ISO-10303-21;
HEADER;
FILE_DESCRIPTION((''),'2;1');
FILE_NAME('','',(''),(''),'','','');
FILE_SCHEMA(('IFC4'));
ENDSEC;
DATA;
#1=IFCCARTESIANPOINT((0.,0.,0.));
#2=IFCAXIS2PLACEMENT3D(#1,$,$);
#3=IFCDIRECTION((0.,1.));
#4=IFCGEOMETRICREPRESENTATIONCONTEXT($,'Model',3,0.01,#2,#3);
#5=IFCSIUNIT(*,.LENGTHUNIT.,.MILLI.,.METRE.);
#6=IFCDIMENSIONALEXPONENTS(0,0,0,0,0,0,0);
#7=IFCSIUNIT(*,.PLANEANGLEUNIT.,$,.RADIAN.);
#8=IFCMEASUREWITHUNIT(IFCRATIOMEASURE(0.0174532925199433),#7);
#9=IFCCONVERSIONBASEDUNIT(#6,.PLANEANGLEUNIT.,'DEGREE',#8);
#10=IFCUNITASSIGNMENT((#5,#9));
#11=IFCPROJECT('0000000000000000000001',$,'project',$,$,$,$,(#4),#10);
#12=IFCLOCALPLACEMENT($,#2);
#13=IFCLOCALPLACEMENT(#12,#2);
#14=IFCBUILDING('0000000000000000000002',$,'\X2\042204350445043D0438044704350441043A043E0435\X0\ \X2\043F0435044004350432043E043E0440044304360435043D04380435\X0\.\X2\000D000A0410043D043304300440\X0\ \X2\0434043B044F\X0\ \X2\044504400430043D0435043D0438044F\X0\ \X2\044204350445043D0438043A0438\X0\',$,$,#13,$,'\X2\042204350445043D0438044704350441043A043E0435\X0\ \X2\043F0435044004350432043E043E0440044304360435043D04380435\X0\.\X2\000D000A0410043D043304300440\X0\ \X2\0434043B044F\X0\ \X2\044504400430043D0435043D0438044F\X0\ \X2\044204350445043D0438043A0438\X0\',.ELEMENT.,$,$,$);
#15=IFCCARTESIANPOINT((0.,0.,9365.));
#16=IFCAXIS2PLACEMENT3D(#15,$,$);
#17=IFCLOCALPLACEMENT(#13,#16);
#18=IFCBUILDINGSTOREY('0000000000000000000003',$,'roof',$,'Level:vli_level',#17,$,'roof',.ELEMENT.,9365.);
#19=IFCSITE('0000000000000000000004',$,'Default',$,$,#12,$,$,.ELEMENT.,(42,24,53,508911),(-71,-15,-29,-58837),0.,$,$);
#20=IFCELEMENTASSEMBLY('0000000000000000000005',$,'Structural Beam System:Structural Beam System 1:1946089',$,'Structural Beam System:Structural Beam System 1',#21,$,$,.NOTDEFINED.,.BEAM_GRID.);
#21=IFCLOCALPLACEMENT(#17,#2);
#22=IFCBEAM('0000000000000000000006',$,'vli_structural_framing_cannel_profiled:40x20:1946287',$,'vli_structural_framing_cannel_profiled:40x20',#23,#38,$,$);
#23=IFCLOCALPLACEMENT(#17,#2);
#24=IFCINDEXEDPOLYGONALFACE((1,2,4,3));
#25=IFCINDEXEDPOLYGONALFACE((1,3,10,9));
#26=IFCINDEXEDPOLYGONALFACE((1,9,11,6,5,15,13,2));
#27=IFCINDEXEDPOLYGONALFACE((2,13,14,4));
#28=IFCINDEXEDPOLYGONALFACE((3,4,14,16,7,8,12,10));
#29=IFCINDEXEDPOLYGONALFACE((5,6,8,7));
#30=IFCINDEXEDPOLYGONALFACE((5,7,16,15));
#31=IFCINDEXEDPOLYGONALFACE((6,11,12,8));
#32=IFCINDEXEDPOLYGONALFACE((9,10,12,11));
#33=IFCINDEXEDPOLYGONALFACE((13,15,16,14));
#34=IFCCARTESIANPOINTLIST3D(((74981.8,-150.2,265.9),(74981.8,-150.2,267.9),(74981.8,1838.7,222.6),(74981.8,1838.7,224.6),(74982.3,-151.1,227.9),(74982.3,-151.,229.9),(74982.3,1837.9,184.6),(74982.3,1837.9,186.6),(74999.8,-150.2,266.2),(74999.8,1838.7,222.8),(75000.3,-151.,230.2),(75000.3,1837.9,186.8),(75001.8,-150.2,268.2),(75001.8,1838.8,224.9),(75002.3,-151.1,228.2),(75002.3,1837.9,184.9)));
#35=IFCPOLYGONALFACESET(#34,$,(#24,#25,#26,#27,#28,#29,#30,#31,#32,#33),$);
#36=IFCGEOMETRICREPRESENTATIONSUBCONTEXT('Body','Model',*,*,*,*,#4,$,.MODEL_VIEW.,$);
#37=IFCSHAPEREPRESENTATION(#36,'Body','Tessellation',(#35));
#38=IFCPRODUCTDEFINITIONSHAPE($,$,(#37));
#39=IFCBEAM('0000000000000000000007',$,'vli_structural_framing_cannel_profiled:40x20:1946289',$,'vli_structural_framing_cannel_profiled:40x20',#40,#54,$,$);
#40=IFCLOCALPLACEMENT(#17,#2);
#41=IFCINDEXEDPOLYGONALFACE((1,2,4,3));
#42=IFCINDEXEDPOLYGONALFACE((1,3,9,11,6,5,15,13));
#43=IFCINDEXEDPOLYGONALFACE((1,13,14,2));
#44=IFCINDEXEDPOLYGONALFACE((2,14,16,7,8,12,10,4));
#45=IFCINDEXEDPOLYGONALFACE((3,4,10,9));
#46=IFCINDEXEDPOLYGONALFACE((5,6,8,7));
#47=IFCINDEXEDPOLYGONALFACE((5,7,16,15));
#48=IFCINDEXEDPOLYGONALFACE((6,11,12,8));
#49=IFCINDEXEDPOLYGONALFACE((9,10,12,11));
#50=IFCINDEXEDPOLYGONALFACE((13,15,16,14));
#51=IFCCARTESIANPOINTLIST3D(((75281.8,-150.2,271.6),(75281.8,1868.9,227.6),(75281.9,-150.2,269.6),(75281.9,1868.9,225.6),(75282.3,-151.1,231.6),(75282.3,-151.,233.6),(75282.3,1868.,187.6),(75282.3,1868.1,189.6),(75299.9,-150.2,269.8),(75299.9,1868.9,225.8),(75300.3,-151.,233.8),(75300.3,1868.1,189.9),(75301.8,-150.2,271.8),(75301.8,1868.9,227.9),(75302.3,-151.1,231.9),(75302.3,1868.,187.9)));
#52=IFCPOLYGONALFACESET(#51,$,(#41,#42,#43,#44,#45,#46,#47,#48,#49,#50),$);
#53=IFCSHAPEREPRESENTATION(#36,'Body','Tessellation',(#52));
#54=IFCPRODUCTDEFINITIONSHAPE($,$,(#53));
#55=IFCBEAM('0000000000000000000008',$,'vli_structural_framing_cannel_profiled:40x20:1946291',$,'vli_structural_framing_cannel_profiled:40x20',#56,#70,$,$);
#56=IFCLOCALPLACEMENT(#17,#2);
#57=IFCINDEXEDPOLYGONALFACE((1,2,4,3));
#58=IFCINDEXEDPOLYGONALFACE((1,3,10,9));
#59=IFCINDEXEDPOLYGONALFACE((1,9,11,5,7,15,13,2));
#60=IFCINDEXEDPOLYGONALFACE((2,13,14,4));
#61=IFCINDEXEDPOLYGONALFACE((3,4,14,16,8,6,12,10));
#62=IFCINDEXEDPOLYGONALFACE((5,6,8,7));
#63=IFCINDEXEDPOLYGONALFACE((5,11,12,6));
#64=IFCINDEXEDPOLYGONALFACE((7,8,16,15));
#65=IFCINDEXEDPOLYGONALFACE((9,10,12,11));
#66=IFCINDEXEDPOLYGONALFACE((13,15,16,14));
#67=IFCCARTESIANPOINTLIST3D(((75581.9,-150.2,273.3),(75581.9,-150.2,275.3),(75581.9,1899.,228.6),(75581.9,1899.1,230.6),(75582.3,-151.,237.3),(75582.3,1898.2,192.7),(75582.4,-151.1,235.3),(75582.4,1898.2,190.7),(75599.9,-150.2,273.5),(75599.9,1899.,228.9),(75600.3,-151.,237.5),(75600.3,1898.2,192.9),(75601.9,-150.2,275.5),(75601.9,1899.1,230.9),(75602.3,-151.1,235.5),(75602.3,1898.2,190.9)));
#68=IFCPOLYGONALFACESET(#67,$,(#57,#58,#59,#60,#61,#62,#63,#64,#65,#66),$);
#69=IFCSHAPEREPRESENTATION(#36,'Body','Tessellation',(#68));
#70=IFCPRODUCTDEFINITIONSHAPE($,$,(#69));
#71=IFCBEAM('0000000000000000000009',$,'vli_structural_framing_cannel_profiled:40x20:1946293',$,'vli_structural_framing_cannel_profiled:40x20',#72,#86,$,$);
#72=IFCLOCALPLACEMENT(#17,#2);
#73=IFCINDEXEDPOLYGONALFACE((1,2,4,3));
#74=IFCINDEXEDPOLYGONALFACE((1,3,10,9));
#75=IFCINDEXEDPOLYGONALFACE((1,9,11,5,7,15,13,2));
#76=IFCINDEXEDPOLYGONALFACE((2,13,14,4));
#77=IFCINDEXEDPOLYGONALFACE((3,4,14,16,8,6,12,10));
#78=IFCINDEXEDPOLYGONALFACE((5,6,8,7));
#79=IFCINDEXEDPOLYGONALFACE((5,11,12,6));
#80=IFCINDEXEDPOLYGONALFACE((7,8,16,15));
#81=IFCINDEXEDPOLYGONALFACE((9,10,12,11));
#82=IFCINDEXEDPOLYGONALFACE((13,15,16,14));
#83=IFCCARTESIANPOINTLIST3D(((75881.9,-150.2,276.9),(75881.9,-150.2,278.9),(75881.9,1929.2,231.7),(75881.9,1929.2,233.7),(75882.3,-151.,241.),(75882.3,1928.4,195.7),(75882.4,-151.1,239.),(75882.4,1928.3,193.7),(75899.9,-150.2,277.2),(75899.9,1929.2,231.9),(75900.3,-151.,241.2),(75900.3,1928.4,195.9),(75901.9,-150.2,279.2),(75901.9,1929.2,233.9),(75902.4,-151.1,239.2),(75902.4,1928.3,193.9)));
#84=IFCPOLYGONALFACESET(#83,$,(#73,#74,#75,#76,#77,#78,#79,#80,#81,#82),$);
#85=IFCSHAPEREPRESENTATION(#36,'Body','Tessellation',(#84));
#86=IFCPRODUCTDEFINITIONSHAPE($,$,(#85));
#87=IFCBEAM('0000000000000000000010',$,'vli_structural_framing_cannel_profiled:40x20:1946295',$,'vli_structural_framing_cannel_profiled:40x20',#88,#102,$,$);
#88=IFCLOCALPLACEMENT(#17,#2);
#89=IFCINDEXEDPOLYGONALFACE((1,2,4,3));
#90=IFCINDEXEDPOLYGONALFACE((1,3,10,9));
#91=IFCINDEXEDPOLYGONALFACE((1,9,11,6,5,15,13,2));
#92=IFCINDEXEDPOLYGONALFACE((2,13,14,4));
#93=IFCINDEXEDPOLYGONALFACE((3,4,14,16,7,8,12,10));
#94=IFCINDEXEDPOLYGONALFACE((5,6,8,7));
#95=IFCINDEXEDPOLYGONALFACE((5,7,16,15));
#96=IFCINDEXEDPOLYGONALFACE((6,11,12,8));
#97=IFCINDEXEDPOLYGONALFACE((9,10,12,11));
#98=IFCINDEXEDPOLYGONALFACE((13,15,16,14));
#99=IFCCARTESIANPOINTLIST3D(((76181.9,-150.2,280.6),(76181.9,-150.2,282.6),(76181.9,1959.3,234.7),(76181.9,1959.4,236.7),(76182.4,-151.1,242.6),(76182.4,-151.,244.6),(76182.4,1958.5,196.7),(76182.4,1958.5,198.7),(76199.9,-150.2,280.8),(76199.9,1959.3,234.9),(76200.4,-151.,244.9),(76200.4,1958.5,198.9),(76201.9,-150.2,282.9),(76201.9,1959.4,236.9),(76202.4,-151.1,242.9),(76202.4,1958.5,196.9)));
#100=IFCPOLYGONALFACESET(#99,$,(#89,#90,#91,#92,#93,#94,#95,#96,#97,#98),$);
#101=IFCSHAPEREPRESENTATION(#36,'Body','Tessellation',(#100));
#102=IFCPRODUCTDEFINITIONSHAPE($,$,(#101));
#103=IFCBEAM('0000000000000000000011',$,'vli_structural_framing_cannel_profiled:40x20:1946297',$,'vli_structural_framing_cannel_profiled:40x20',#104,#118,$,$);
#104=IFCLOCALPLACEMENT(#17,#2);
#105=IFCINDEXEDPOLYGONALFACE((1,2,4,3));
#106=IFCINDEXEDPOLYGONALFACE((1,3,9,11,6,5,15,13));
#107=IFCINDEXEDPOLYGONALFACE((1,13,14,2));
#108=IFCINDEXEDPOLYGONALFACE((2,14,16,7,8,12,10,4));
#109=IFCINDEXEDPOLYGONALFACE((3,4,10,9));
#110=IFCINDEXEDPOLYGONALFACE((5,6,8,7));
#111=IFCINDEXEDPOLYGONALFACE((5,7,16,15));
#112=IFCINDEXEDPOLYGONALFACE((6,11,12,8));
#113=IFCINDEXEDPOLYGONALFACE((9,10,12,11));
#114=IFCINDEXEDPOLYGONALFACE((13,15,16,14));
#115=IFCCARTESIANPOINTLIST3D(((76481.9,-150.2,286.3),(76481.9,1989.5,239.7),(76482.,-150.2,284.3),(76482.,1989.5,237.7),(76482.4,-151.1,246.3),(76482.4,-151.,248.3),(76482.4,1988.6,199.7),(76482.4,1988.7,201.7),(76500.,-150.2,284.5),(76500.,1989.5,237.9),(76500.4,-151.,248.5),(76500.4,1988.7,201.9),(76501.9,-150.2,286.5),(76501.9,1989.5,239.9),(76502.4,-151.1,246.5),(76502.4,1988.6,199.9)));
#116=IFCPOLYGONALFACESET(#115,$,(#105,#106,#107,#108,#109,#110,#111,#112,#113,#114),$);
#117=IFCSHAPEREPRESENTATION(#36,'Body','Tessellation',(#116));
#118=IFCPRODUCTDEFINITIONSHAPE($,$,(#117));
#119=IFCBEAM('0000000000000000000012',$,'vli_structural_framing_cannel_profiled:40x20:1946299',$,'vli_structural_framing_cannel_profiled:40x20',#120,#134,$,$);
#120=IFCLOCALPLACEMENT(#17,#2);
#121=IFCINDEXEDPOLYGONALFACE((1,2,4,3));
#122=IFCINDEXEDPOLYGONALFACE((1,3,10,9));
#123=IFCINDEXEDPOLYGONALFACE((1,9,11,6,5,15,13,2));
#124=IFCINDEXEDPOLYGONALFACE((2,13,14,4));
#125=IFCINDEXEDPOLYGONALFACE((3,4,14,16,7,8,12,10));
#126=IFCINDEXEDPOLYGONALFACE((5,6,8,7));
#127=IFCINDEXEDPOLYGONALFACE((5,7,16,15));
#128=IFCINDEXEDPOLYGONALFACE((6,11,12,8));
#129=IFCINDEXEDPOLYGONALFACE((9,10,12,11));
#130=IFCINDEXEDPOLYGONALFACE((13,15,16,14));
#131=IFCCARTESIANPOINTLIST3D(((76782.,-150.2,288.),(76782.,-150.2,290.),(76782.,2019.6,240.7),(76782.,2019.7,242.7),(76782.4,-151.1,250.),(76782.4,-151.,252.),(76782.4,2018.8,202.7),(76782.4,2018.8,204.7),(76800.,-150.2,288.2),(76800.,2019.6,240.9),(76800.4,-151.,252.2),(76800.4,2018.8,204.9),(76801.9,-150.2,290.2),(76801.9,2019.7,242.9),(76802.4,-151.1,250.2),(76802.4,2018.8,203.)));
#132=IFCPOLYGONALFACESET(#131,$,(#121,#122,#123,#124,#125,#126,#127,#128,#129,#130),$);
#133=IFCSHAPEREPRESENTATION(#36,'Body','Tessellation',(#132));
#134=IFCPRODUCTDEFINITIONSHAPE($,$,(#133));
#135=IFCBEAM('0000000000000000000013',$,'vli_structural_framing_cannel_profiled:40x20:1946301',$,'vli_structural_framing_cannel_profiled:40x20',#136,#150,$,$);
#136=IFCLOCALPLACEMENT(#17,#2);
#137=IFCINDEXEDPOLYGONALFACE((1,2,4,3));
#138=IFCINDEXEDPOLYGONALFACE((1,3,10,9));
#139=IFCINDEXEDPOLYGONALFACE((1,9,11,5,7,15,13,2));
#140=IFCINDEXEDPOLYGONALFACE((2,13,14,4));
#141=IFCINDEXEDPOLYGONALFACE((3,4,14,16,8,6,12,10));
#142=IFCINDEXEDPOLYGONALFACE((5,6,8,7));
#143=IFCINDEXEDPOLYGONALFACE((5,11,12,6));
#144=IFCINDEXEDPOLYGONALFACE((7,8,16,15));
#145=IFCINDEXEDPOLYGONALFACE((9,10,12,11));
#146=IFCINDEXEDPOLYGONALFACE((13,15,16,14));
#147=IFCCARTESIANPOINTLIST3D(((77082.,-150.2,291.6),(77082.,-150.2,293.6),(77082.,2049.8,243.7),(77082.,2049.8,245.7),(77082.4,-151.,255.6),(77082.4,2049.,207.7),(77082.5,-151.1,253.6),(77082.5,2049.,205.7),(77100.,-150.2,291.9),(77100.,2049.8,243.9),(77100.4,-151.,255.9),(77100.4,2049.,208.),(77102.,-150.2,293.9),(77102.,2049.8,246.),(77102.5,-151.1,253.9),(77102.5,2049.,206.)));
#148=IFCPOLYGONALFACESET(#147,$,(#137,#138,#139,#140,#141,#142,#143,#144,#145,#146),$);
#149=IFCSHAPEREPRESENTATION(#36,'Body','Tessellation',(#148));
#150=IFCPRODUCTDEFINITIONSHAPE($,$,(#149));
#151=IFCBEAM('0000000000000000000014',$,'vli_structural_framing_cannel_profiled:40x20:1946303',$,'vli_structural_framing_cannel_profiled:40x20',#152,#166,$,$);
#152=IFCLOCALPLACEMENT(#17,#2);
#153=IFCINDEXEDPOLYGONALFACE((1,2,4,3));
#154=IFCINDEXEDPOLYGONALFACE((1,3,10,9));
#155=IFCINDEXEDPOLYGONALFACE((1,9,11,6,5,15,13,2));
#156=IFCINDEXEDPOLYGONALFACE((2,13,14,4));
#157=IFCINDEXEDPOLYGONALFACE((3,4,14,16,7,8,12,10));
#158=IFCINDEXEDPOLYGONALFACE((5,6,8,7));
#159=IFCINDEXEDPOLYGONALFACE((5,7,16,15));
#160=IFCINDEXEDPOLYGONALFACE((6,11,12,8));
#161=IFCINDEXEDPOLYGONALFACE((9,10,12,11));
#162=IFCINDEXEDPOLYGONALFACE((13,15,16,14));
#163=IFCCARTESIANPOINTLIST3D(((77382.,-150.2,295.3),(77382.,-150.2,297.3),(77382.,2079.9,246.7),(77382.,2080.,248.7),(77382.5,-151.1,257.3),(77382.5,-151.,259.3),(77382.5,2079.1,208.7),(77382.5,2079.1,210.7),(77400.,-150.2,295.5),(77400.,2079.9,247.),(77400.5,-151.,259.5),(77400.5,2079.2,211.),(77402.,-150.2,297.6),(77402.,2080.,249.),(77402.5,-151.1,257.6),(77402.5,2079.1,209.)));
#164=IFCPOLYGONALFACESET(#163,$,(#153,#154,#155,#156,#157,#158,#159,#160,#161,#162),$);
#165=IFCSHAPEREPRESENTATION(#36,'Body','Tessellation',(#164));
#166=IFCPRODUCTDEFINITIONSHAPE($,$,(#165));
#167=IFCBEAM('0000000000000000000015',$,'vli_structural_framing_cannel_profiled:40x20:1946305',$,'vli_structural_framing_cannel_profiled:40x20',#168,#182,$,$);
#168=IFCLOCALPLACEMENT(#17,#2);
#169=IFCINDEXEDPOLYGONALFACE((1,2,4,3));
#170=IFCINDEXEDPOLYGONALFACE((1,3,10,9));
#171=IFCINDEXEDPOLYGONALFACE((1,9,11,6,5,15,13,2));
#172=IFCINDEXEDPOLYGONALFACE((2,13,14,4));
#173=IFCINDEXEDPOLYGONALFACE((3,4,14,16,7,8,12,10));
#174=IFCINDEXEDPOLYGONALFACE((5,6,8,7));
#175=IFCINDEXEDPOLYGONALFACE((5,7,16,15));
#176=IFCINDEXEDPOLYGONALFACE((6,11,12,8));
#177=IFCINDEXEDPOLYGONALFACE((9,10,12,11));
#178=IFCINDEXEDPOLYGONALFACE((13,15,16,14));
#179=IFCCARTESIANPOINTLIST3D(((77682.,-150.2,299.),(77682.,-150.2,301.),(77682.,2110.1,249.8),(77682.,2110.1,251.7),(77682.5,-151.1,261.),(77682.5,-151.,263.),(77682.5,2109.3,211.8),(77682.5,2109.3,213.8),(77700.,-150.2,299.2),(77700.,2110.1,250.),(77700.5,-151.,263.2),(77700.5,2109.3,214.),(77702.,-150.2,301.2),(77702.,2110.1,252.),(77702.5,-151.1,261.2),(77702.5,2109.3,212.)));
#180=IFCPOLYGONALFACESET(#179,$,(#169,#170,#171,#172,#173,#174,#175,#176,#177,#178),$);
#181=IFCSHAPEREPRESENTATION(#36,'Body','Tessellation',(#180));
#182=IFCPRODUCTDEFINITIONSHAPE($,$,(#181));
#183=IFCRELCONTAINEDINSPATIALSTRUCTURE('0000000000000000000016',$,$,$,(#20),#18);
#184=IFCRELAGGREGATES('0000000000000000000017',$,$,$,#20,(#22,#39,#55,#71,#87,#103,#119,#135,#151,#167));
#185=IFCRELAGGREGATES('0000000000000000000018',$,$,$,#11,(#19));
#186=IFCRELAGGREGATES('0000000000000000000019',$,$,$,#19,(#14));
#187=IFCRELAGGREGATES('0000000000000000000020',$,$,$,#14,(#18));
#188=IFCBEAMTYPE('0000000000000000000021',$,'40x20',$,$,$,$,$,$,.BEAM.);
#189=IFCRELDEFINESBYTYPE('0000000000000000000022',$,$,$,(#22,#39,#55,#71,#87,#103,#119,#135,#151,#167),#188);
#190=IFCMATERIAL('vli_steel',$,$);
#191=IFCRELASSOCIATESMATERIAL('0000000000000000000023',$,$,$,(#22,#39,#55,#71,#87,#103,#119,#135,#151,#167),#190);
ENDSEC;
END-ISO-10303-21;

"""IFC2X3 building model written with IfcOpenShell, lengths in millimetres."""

from ifc_helpers import new_model, entity, si_unit, converted_unit, direction, frame, origin, place, context, subcontext, project, spatial, polyline, outline, extrude, material, type_object, element, aggregate, save


model = new_model("IFC2X3")

# Units and contexts
model_context = context("Model", 3, precision=0.01, world=origin(), true_north=direction((0.0, 1.0)))
body_context = subcontext(model_context, "Body", "Model", "MODEL_VIEW")
ifc_project = project(units=[si_unit("LENGTHUNIT", "METRE", prefix="MILLI"), converted_unit("PLANEANGLEUNIT", "DEGREE", entity("IfcRatioMeasure", 0.0174532925199433), si_unit("PLANEANGLEUNIT", "RADIAN"), dimensions=[0, 0, 0, 0, 0, 0, 0])], contexts=[model_context])

# Site, building, storey
site_placement = place(None, origin())
site = spatial("IfcSite", under=ifc_project, at=site_placement, Name="Default", CompositionType="ELEMENT", RefLatitude=(42, 24, 53, 508911), RefLongitude=(-71, -15, -29, -58837), RefElevation=0.0)
building_placement = place(site_placement, origin())
building = spatial("IfcBuilding", under=site, at=building_placement, Name="Техническое перевооружение.\r\nАнгар для хранения техники", LongName="Техническое перевооружение.\r\nАнгар для хранения техники", CompositionType="ELEMENT")
storey_placement = place(building_placement, frame((0.0, 0.0, 9365.0)))
storey = spatial("IfcBuildingStorey", under=building, at=storey_placement, Name="roof", ObjectType="Level:vli_level", LongName="roof", CompositionType="ELEMENT", Elevation=9365.0)

# Element assembly, beams
ifc_material = material(Name="vli_steel")
beam_type = type_object("IfcBeamType", Name="40x20", PredefinedType="BEAM")
assembly_1_placement = place(storey_placement, origin())
assembly_1 = element("IfcElementAssembly", 1, at=assembly_1_placement, inside=storey, Name="Structural Beam System:Structural Beam System 1:1946089", ObjectType="Structural Beam System:Structural Beam System 1", AssemblyPlace="NOTDEFINED", PredefinedType="BEAM_GRID")
beam_1_placement = place(assembly_1_placement, frame((75001.2, 1838.8, 224.8), z_axis=(0.0, 0.021775, 0.999763), x_axis=(0.0, -0.999763, 0.021775)))
beam_1 = element("IfcBeam", 2, at=beam_1_placement, type_object=beam_type, material=ifc_material, Name="vli_structural_framing_cannel_profiled:40x20:1946287", ObjectType="vli_structural_framing_cannel_profiled:40x20", context=body_context, shape_type="SweptSolid", body=[
    extrude(outline(polyline([(-10.5, -20.0), (9.5, -20.0), (9.5, -18.0), (-8.5, -18.0), (-8.5, 18.0), (9.5, 18.0), (9.5, 20.0), (-10.5, 20.0), (-10.5, -20.0)])), frame((0.0, -9.7, -20.1), z_axis=(1.0, 0.0, 0.0), x_axis=(0.0, -0.999925, -0.01227)), (0.0, 0.0, 1.0), 1989.4),
])
beam_2_placement = place(assembly_1_placement, frame((75301.2, 1868.9, 227.9), z_axis=(0.0, 0.021775, 0.999763), x_axis=(0.0, -0.999763, 0.021775)))
beam_2 = element("IfcBeam", 3, at=beam_2_placement, type_object=beam_type, material=ifc_material, Name="vli_structural_framing_cannel_profiled:40x20:1946289", ObjectType="vli_structural_framing_cannel_profiled:40x20", context=body_context, shape_type="SweptSolid", body=[
    extrude(outline(polyline([(-10.5, -20.0), (9.5, -20.0), (9.5, -18.0), (-8.5, -18.0), (-8.5, 18.0), (9.5, 18.0), (9.5, 20.0), (-10.5, 20.0), (-10.5, -20.0)])), frame((0.0, -9.7, -20.1), z_axis=(1.0, 0.0, 0.0), x_axis=(0.0, -0.999925, -0.01227)), (0.0, 0.0, 1.0), 2019.6),
])
beam_3_placement = place(assembly_1_placement, frame((75601.3, 1899.1, 230.9), z_axis=(0.0, 0.021775, 0.999763), x_axis=(0.0, -0.999763, 0.021775)))
beam_3 = element("IfcBeam", 4, at=beam_3_placement, type_object=beam_type, material=ifc_material, Name="vli_structural_framing_cannel_profiled:40x20:1946291", ObjectType="vli_structural_framing_cannel_profiled:40x20", context=body_context, shape_type="SweptSolid", body=[
    extrude(outline(polyline([(-10.5, -20.0), (9.5, -20.0), (9.5, -18.0), (-8.5, -18.0), (-8.5, 18.0), (9.5, 18.0), (9.5, 20.0), (-10.5, 20.0), (-10.5, -20.0)])), frame((0.0, -9.7, -20.1), z_axis=(1.0, 0.0, 0.0), x_axis=(0.0, -0.999925, -0.01227)), (0.0, 0.0, 1.0), 2049.7),
])
beam_4_placement = place(assembly_1_placement, frame((75901.3, 1929.2, 233.9), z_axis=(0.0, 0.021775, 0.999763), x_axis=(0.0, -0.999763, 0.021775)))
beam_4 = element("IfcBeam", 5, at=beam_4_placement, type_object=beam_type, material=ifc_material, Name="vli_structural_framing_cannel_profiled:40x20:1946293", ObjectType="vli_structural_framing_cannel_profiled:40x20", context=body_context, shape_type="SweptSolid", body=[
    extrude(outline(polyline([(-10.5, -20.0), (9.5, -20.0), (9.5, -18.0), (-8.5, -18.0), (-8.5, 18.0), (9.5, 18.0), (9.5, 20.0), (-10.5, 20.0), (-10.5, -20.0)])), frame((0.0, -9.7, -20.1), z_axis=(1.0, 0.0, 0.0), x_axis=(0.0, -0.999925, -0.01227)), (0.0, 0.0, 1.0), 2079.9),
])
beam_5_placement = place(assembly_1_placement, frame((76201.3, 1959.4, 236.9), z_axis=(0.0, 0.021775, 0.999763), x_axis=(0.0, -0.999763, 0.021775)))
beam_5 = element("IfcBeam", 6, at=beam_5_placement, type_object=beam_type, material=ifc_material, Name="vli_structural_framing_cannel_profiled:40x20:1946295", ObjectType="vli_structural_framing_cannel_profiled:40x20", context=body_context, shape_type="SweptSolid", body=[
    extrude(outline(polyline([(-10.5, -20.0), (9.5, -20.0), (9.5, -18.0), (-8.5, -18.0), (-8.5, 18.0), (9.5, 18.0), (9.5, 20.0), (-10.5, 20.0), (-10.5, -20.0)])), frame((0.0, -9.7, -20.1), z_axis=(1.0, 0.0, 0.0), x_axis=(0.0, -0.999925, -0.01227)), (0.0, 0.0, 1.0), 2110.1),
])
beam_6_placement = place(assembly_1_placement, frame((76501.3, 1989.5, 239.9), z_axis=(0.0, 0.021775, 0.999763), x_axis=(0.0, -0.999763, 0.021775)))
beam_6 = element("IfcBeam", 7, at=beam_6_placement, type_object=beam_type, material=ifc_material, Name="vli_structural_framing_cannel_profiled:40x20:1946297", ObjectType="vli_structural_framing_cannel_profiled:40x20", context=body_context, shape_type="SweptSolid", body=[
    extrude(outline(polyline([(-10.5, -20.0), (9.5, -20.0), (9.5, -18.0), (-8.5, -18.0), (-8.5, 18.0), (9.5, 18.0), (9.5, 20.0), (-10.5, 20.0), (-10.5, -20.0)])), frame((0.0, -9.7, -20.1), z_axis=(1.0, 0.0, 0.0), x_axis=(0.0, -0.999925, -0.01227)), (0.0, 0.0, 1.0), 2140.2),
])
beam_7_placement = place(assembly_1_placement, frame((76801.3, 2019.7, 242.9), z_axis=(0.0, 0.021775, 0.999763), x_axis=(0.0, -0.999763, 0.021775)))
beam_7 = element("IfcBeam", 8, at=beam_7_placement, type_object=beam_type, material=ifc_material, Name="vli_structural_framing_cannel_profiled:40x20:1946299", ObjectType="vli_structural_framing_cannel_profiled:40x20", context=body_context, shape_type="SweptSolid", body=[
    extrude(outline(polyline([(-10.5, -20.0), (9.5, -20.0), (9.5, -18.0), (-8.5, -18.0), (-8.5, 18.0), (9.5, 18.0), (9.5, 20.0), (-10.5, 20.0), (-10.5, -20.0)])), frame((0.0, -9.7, -20.1), z_axis=(1.0, 0.0, 0.0), x_axis=(0.0, -0.999925, -0.01227)), (0.0, 0.0, 1.0), 2170.4),
])
beam_8_placement = place(assembly_1_placement, frame((77101.4, 2049.8, 246.0), z_axis=(0.0, 0.021775, 0.999763), x_axis=(0.0, -0.999763, 0.021775)))
beam_8 = element("IfcBeam", 9, at=beam_8_placement, type_object=beam_type, material=ifc_material, Name="vli_structural_framing_cannel_profiled:40x20:1946301", ObjectType="vli_structural_framing_cannel_profiled:40x20", context=body_context, shape_type="SweptSolid", body=[
    extrude(outline(polyline([(-10.5, -20.0), (9.5, -20.0), (9.5, -18.0), (-8.5, -18.0), (-8.5, 18.0), (9.5, 18.0), (9.5, 20.0), (-10.5, 20.0), (-10.5, -20.0)])), frame((0.0, -9.7, -20.1), z_axis=(1.0, 0.0, 0.0), x_axis=(0.0, -0.999925, -0.01227)), (0.0, 0.0, 1.0), 2200.5),
])
beam_9_placement = place(assembly_1_placement, frame((77401.4, 2080.0, 249.0), z_axis=(0.0, 0.021775, 0.999763), x_axis=(0.0, -0.999763, 0.021775)))
beam_9 = element("IfcBeam", 10, at=beam_9_placement, type_object=beam_type, material=ifc_material, Name="vli_structural_framing_cannel_profiled:40x20:1946303", ObjectType="vli_structural_framing_cannel_profiled:40x20", context=body_context, shape_type="SweptSolid", body=[
    extrude(outline(polyline([(-10.5, -20.0), (9.5, -20.0), (9.5, -18.0), (-8.5, -18.0), (-8.5, 18.0), (9.5, 18.0), (9.5, 20.0), (-10.5, 20.0), (-10.5, -20.0)])), frame((0.0, -9.7, -20.1), z_axis=(1.0, 0.0, 0.0), x_axis=(0.0, -0.999925, -0.01227)), (0.0, 0.0, 1.0), 2230.7),
])
beam_10_placement = place(assembly_1_placement, frame((77701.4, 2110.1, 252.0), z_axis=(0.0, 0.021775, 0.999763), x_axis=(0.0, -0.999763, 0.021775)))
beam_10 = element("IfcBeam", 11, at=beam_10_placement, type_object=beam_type, material=ifc_material, Name="vli_structural_framing_cannel_profiled:40x20:1946305", ObjectType="vli_structural_framing_cannel_profiled:40x20", context=body_context, shape_type="SweptSolid", body=[
    extrude(outline(polyline([(-10.5, -20.0), (9.5, -20.0), (9.5, -18.0), (-8.5, -18.0), (-8.5, 18.0), (9.5, 18.0), (9.5, 20.0), (-10.5, 20.0), (-10.5, -20.0)])), frame((0.0, -9.7, -20.1), z_axis=(1.0, 0.0, 0.0), x_axis=(0.0, -0.999925, -0.01227)), (0.0, 0.0, 1.0), 2260.9),
])
aggregate(assembly_1, [beam_1, beam_2, beam_3, beam_4, beam_5, beam_6, beam_7, beam_8, beam_9, beam_10])

save(model, "model.ifc")
